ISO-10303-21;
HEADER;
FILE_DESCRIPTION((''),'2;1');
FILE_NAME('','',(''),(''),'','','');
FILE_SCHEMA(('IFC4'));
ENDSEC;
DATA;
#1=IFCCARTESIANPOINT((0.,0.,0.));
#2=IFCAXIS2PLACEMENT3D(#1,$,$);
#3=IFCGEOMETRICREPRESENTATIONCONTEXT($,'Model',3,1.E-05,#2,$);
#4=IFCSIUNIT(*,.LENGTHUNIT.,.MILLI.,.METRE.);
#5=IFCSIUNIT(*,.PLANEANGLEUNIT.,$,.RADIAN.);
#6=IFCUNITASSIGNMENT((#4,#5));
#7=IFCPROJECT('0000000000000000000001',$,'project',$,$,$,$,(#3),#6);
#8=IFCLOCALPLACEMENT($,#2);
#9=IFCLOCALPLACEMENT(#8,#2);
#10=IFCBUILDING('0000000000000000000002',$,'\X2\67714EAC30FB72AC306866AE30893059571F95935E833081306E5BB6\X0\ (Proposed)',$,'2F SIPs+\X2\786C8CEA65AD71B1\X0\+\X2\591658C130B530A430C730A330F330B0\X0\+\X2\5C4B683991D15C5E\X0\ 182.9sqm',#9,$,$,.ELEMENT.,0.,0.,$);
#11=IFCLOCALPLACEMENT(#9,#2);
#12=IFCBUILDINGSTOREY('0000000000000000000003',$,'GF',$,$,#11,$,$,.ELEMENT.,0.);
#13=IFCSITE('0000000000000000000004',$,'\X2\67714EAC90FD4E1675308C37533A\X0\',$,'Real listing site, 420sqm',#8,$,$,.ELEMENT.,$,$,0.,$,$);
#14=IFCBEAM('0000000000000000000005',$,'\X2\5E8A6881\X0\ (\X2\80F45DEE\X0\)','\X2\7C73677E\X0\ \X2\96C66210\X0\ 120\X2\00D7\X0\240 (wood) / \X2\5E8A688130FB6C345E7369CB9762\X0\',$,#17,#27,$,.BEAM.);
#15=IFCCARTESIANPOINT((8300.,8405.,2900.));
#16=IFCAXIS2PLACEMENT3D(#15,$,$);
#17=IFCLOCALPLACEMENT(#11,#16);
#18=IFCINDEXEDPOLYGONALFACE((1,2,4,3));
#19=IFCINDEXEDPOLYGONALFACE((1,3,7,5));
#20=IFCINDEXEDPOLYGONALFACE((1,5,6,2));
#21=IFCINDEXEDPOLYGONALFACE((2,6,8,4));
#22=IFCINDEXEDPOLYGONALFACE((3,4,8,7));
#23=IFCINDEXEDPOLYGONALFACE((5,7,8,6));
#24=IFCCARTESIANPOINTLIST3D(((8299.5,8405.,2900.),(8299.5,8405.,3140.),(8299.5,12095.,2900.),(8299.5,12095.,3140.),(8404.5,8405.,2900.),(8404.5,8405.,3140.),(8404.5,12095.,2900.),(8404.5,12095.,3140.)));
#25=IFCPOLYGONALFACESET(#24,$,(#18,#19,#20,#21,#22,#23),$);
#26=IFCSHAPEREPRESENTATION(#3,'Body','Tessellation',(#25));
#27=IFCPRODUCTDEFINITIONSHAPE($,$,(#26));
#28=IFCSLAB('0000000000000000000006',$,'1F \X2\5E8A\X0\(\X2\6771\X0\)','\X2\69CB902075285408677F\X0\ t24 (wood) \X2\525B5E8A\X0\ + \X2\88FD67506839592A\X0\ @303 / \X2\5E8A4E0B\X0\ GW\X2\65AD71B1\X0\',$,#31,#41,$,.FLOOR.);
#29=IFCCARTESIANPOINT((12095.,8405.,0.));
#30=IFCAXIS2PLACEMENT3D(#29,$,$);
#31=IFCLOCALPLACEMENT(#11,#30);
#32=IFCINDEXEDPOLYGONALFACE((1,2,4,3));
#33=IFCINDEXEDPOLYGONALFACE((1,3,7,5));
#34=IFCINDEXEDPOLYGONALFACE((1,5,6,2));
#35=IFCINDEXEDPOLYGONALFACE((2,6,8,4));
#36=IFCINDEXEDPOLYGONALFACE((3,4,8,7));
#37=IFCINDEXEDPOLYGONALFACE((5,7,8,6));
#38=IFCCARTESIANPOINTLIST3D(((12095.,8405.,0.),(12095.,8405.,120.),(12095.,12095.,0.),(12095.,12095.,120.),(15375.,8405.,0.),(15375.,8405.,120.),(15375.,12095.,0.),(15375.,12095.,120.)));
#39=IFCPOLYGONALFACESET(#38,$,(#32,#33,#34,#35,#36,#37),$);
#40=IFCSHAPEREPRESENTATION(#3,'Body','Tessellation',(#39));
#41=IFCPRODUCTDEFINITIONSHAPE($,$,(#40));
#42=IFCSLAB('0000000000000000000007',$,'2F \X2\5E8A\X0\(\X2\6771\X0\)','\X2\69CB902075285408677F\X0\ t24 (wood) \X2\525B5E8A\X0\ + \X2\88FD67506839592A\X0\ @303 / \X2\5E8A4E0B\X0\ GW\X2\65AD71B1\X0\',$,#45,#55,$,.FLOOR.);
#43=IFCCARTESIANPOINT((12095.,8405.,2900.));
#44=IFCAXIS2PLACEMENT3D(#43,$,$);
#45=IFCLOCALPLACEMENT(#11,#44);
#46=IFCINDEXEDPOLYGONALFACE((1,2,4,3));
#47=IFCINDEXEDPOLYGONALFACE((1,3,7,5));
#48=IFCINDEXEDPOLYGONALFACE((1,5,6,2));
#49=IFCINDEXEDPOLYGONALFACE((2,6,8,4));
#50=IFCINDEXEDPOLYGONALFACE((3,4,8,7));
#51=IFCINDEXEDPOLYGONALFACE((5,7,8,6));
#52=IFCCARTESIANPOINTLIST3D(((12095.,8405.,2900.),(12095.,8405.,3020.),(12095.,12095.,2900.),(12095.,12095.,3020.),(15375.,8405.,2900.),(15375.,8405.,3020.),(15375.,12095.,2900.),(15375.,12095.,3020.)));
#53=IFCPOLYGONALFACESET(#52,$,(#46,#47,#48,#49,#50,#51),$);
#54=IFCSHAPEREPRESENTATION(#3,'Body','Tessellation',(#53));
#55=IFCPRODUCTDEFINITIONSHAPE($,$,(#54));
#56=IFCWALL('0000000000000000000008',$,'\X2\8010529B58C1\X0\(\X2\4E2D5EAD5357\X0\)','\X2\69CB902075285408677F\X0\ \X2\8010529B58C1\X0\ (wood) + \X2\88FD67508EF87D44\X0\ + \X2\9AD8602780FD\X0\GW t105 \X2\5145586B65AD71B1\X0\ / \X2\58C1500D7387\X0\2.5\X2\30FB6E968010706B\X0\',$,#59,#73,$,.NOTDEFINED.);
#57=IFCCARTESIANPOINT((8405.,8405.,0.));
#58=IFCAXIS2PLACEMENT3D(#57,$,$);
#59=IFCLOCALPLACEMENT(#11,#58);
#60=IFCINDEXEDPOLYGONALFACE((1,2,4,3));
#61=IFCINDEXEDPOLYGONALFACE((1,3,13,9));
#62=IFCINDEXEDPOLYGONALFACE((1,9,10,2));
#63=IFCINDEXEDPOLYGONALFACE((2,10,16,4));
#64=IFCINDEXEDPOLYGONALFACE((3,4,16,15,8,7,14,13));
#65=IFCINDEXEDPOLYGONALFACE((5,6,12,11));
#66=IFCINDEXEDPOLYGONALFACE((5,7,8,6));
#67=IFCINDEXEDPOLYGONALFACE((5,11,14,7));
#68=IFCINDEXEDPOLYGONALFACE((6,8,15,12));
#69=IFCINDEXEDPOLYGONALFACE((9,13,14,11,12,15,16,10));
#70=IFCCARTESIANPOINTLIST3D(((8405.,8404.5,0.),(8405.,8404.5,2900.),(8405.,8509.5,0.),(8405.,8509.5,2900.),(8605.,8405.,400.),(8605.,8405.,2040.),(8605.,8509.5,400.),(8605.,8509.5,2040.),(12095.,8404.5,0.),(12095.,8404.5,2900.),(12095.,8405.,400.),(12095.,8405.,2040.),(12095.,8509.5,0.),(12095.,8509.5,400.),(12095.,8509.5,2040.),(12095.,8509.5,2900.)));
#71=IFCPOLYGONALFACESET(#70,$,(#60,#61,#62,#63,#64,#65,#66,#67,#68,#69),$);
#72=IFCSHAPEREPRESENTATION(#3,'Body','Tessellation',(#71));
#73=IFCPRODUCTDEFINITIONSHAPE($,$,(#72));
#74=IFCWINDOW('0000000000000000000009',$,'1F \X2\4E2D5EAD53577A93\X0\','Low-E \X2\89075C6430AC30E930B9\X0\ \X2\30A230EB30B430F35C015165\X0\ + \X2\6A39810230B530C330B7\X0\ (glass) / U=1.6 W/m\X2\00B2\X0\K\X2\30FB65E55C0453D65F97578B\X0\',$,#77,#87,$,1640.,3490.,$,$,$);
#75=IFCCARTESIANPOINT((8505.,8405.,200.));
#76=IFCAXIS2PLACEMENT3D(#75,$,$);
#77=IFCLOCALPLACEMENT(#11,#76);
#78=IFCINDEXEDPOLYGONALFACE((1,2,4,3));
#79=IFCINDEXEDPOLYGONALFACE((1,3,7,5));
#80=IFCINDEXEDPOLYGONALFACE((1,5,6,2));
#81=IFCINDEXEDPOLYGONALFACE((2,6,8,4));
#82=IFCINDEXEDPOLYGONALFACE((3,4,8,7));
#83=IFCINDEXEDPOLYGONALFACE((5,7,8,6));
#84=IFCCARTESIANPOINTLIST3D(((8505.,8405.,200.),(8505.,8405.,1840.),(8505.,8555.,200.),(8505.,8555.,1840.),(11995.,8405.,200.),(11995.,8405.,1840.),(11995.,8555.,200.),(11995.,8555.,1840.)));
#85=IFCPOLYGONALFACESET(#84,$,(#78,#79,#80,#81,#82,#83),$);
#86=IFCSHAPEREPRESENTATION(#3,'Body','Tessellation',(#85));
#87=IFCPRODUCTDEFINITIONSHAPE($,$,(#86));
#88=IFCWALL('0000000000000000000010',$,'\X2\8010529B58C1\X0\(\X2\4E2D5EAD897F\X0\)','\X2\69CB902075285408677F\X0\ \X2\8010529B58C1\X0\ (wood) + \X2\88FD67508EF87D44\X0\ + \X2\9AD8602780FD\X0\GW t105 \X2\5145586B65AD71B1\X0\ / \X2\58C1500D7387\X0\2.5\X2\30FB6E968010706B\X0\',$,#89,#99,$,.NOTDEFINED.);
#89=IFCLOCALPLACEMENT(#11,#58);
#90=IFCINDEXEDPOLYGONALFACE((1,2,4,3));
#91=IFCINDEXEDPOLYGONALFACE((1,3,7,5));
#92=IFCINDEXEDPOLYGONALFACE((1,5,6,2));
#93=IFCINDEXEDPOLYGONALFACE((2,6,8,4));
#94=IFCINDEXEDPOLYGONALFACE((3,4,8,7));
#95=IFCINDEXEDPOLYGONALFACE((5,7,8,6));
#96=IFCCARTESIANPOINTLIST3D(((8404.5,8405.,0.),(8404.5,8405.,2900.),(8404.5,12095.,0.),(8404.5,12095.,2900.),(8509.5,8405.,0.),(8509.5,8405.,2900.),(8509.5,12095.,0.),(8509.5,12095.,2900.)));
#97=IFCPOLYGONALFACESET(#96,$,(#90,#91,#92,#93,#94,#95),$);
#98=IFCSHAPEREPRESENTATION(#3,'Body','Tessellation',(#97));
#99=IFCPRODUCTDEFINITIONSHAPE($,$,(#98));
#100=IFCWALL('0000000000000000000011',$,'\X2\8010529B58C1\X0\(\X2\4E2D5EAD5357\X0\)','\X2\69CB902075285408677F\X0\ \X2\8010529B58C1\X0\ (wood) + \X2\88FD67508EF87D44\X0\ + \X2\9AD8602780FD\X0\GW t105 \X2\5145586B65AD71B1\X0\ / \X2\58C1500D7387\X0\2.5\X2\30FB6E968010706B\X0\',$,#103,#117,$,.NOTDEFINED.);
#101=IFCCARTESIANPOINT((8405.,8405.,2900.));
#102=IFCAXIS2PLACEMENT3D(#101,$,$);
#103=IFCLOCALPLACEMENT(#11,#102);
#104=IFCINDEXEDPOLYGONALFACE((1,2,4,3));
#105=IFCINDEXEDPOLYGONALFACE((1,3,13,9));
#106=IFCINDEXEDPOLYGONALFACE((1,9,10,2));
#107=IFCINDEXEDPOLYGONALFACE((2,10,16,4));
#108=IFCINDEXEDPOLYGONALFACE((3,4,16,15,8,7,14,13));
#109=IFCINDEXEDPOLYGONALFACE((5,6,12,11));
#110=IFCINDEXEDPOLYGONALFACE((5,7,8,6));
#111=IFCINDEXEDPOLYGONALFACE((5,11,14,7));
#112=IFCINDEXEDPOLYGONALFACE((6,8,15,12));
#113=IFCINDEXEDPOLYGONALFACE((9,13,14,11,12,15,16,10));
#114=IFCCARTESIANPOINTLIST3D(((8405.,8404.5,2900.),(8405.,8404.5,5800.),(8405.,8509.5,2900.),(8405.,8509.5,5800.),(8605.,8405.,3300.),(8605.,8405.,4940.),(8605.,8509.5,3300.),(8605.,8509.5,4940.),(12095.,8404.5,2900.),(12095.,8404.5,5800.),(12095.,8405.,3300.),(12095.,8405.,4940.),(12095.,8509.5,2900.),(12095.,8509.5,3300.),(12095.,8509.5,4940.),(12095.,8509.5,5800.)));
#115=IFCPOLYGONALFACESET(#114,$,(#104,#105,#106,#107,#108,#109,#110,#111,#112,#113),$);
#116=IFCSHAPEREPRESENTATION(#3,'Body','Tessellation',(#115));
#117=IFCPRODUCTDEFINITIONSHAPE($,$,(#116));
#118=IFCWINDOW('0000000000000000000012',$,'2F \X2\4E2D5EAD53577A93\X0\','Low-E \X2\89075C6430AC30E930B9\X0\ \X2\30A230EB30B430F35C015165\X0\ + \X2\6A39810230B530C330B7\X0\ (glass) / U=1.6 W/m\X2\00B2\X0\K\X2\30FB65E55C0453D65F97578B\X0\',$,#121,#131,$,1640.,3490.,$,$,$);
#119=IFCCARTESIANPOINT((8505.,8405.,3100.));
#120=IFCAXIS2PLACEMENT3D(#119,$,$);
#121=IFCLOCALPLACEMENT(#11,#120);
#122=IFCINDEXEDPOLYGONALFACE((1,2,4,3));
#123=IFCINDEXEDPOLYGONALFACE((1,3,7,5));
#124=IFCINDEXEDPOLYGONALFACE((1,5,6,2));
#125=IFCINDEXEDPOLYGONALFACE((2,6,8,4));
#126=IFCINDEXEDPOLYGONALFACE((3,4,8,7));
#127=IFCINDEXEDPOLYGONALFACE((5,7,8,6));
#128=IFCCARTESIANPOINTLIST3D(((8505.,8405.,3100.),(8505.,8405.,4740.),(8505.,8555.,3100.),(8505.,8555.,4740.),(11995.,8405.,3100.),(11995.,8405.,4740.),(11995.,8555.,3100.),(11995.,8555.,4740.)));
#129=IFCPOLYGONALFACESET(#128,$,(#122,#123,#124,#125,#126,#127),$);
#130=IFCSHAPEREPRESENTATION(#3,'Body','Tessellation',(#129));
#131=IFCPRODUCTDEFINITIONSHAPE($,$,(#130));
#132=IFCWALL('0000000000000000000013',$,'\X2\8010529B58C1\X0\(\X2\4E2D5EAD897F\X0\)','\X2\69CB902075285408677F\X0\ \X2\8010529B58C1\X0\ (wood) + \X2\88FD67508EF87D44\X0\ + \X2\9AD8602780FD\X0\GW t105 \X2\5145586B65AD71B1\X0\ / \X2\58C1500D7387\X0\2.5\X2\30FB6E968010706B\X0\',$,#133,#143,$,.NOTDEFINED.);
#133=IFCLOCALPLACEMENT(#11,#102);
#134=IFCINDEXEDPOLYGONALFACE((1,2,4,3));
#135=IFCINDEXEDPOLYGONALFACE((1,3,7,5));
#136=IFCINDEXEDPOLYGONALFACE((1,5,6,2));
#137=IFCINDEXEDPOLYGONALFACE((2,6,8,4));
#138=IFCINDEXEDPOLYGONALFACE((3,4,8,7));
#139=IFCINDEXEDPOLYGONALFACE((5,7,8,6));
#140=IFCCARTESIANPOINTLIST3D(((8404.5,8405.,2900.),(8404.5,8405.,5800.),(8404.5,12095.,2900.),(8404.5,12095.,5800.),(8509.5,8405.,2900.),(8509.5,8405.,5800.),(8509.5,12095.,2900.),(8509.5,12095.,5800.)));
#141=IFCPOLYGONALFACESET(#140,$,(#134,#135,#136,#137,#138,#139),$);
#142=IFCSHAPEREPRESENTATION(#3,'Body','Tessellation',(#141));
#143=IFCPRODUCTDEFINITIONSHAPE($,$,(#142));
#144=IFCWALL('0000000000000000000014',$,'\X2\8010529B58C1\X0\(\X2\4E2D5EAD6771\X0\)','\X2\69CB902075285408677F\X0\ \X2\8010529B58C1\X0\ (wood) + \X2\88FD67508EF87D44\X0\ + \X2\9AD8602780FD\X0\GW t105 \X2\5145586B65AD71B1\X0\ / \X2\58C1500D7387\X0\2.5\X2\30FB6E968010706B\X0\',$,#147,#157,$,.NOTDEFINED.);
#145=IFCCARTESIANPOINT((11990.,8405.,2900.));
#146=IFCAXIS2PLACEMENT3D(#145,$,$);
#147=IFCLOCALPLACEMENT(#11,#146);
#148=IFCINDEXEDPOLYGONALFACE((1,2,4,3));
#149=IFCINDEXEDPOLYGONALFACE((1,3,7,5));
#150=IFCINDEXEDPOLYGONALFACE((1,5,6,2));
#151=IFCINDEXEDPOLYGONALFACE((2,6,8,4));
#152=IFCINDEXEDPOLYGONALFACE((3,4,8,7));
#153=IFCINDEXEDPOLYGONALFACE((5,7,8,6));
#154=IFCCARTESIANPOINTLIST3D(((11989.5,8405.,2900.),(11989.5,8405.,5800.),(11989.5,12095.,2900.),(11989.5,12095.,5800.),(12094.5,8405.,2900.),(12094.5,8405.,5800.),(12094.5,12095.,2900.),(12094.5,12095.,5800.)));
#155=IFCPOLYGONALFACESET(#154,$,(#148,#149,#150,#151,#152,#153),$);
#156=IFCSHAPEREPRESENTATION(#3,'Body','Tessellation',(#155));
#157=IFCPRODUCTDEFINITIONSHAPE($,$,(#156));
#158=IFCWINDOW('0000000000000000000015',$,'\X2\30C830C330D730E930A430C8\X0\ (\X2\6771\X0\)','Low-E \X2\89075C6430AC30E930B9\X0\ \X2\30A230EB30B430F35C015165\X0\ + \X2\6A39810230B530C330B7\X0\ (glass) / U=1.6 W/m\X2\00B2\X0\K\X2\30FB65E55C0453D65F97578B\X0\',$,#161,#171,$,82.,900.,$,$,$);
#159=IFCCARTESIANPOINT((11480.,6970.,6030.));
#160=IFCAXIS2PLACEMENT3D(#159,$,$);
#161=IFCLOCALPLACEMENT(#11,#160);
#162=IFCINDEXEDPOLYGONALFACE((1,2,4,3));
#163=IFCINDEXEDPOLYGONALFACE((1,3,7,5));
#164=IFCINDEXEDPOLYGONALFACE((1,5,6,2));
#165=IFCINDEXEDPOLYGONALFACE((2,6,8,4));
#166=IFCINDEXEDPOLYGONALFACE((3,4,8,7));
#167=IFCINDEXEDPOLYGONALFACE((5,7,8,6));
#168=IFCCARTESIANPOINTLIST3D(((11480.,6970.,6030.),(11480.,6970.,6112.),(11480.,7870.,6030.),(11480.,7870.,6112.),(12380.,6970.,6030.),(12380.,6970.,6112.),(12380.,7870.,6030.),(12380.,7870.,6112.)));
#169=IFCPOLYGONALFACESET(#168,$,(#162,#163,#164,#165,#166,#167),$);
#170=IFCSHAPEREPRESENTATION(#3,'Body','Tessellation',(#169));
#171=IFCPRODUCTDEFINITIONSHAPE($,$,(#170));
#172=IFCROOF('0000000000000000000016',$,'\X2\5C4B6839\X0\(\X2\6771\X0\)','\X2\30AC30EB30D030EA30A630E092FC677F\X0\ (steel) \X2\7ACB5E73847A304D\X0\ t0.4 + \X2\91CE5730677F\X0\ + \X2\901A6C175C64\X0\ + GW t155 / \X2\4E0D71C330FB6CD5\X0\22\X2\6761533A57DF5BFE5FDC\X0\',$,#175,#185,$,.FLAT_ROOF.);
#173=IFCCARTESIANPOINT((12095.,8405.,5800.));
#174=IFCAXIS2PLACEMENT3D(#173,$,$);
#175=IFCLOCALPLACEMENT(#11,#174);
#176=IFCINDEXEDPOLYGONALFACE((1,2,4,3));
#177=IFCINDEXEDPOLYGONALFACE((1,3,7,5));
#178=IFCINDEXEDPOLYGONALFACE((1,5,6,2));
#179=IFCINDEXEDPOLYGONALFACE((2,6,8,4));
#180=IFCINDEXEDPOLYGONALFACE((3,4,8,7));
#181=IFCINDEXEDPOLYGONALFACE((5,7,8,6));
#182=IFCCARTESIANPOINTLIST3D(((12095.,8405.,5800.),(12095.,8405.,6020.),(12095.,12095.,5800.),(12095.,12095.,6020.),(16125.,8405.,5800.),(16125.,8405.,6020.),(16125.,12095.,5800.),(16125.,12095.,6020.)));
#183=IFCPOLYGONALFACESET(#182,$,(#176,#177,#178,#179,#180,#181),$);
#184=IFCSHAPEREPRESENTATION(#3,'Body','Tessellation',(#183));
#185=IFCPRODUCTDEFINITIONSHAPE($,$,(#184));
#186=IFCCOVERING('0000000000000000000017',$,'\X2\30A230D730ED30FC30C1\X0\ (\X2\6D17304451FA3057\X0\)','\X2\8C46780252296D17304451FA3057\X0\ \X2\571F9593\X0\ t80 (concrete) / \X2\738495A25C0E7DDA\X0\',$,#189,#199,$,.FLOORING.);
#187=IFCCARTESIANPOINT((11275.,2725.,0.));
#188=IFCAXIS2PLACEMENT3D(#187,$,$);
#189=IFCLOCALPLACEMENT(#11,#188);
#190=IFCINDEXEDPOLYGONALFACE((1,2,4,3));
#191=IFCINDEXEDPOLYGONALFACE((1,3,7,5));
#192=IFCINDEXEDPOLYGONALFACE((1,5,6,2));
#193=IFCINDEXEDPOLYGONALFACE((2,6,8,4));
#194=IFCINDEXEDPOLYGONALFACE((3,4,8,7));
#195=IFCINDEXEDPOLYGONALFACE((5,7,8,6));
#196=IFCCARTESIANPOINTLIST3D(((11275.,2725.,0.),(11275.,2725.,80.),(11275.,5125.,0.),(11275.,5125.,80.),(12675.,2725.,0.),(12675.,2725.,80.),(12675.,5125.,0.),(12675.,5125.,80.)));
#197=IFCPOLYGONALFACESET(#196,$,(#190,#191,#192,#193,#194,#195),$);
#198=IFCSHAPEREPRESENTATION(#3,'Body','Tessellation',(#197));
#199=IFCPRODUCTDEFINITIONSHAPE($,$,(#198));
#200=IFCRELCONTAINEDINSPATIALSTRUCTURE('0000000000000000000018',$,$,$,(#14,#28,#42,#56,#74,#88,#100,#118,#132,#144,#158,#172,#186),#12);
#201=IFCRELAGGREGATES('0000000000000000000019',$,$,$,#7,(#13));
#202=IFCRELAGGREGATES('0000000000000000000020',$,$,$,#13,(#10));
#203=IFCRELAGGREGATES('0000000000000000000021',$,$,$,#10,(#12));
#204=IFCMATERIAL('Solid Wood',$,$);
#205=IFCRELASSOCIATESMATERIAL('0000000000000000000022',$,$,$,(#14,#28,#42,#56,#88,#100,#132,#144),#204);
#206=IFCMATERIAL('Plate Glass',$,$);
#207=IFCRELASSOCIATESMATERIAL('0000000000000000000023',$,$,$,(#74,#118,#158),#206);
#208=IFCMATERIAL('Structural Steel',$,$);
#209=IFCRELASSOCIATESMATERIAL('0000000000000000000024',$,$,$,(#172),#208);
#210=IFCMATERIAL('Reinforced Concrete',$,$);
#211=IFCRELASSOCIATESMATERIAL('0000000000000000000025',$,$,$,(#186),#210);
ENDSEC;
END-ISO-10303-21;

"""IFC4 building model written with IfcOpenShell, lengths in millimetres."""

from ifc_helpers import new_model, si_unit, frame, frame_2d, origin, place, context, project, spatial, rectangle, extrude, material, element, fill, save


model = new_model("IFC4")

# Units and contexts
model_context = context("Model", 3, precision=1e-05, world=origin())
ifc_project = project(units=[si_unit("LENGTHUNIT", "METRE", prefix="MILLI"), si_unit("PLANEANGLEUNIT", "RADIAN")], contexts=[model_context])

# Site, building, storey
site_placement = place(None, origin())
site = spatial("IfcSite", under=ifc_project, at=site_placement, Name="東京都世田谷区", ObjectType="Real listing site, 420sqm", CompositionType="ELEMENT", RefElevation=0.0)
building_placement = place(site_placement, origin())
building = spatial("IfcBuilding", under=site, at=building_placement, Name="東京・犬と暮らす土間広めの家 (Proposed)", ObjectType="2F SIPs+硬質断熱+外壁サイディング+屋根金属 182.9sqm", CompositionType="ELEMENT", ElevationOfRefHeight=0.0, ElevationOfTerrain=0.0)
storey_placement = place(building_placement, origin())
storey = spatial("IfcBuildingStorey", under=building, at=storey_placement, Name="GF", CompositionType="ELEMENT", Elevation=0.0)

# Shared definitions
ifc_material_1 = material(Name="Solid Wood")

# Beam
beam_placement = place(storey_placement, frame((8300.0, 8405.0, 2900.0)))
element("IfcBeam", 1, at=beam_placement, inside=storey, material=ifc_material_1, Name="床梁 (胴差)", Description="米松 集成 120×240 (wood) / 床梁・水平構面", PredefinedType="BEAM", context=model_context, shape_type="SweptSolid", body=[
    extrude(rectangle(XDim=105.0, YDim=3690.0, at=frame_2d((52.0, 1845.0))), frame((8300.0, 8405.0, 2900.0)), (0.0, 0.0, 1.0), 240.0),
])

# Slabs
slab_1_placement = place(storey_placement, frame((12095.0, 8405.0, 0.0)))
element("IfcSlab", 2, at=slab_1_placement, inside=storey, material=ifc_material_1, Name="1F 床(東)", Description="構造用合板 t24 (wood) 剛床 + 製材根太 @303 / 床下 GW断熱", PredefinedType="FLOOR", context=model_context, shape_type="SweptSolid", body=[
    extrude(rectangle(XDim=3280.0, YDim=3690.0, at=frame_2d((1640.0, 1845.0))), frame((12095.0, 8405.0, 0.0)), (0.0, 0.0, 1.0), 120.0),
])
slab_2_placement = place(storey_placement, frame((12095.0, 8405.0, 2900.0)))
element("IfcSlab", 3, at=slab_2_placement, inside=storey, material=ifc_material_1, Name="2F 床(東)", Description="構造用合板 t24 (wood) 剛床 + 製材根太 @303 / 床下 GW断熱", PredefinedType="FLOOR", context=model_context, shape_type="SweptSolid", body=[
    extrude(rectangle(XDim=3280.0, YDim=3690.0, at=frame_2d((1640.0, 1845.0))), frame((12095.0, 8405.0, 2900.0)), (0.0, 0.0, 1.0), 120.0),
])

# Wall, opening, window
wall_1_placement = place(storey_placement, frame((8405.0, 8405.0, 0.0)))
wall_1 = element("IfcWall", 4, at=wall_1_placement, inside=storey, material=ifc_material_1, Name="耐力壁(中庭南)", Description="構造用合板 耐力壁 (wood) + 製材軸組 + 高性能GW t105 充填断熱 / 壁倍率2.5・準耐火", PredefinedType="NOTDEFINED", context=model_context, shape_type="SweptSolid", body=[
    extrude(rectangle(XDim=3690.0, YDim=105.0, at=frame_2d((1845.0, 52.0))), frame((8405.0, 8405.0, 0.0)), (0.0, 0.0, 1.0), 2900.0),
])
opening_1_placement = place(storey_placement, frame((8505.0, 8405.0, 200.0)))
opening_1 = element("IfcOpeningElement", 5, at=opening_1_placement, cuts=wall_1, PredefinedType="NOTDEFINED", context=model_context, shape_type="SweptSolid", body=[
    extrude(rectangle(XDim=3490.0, YDim=150.0, at=frame_2d((1745.0, 75.0))), frame((8505.0, 8405.0, 200.0)), (0.0, 0.0, 1.0), 1640.0),
])
ifc_material_2 = material(Name="Plate Glass")
window_1_placement = place(storey_placement, frame((8505.0, 8405.0, 200.0)))
window_1 = element("IfcWindow", 6, at=window_1_placement, inside=storey, material=ifc_material_2, Name="1F 中庭南窓", Description="Low-E 複層ガラス アルゴン封入 + 樹脂サッシ (glass) / U=1.6 W/m²K・日射取得型", OverallHeight=1640.0, OverallWidth=3490.0, context=model_context, shape_type="SweptSolid", body=[
    extrude(rectangle(XDim=3490.0, YDim=150.0, at=frame_2d((1745.0, 75.0))), frame((8505.0, 8405.0, 200.0)), (0.0, 0.0, 1.0), 1640.0),
])
fill(opening_1, window_1)

# Wall
wall_2_placement = place(storey_placement, frame((8405.0, 8405.0, 0.0)))
element("IfcWall", 7, at=wall_2_placement, inside=storey, material=ifc_material_1, Name="耐力壁(中庭西)", Description="構造用合板 耐力壁 (wood) + 製材軸組 + 高性能GW t105 充填断熱 / 壁倍率2.5・準耐火", PredefinedType="NOTDEFINED", context=model_context, shape_type="SweptSolid", body=[
    extrude(rectangle(XDim=105.0, YDim=3690.0, at=frame_2d((52.0, 1845.0))), frame((8405.0, 8405.0, 0.0)), (0.0, 0.0, 1.0), 2900.0),
])

# Wall, opening, window
wall_3_placement = place(storey_placement, frame((8405.0, 8405.0, 2900.0)))
wall_3 = element("IfcWall", 8, at=wall_3_placement, inside=storey, material=ifc_material_1, Name="耐力壁(中庭南)", Description="構造用合板 耐力壁 (wood) + 製材軸組 + 高性能GW t105 充填断熱 / 壁倍率2.5・準耐火", PredefinedType="NOTDEFINED", context=model_context, shape_type="SweptSolid", body=[
    extrude(rectangle(XDim=3690.0, YDim=105.0, at=frame_2d((1845.0, 52.0))), frame((8405.0, 8405.0, 2900.0)), (0.0, 0.0, 1.0), 2900.0),
])
opening_2_placement = place(storey_placement, frame((8505.0, 8405.0, 3100.0)))
opening_2 = element("IfcOpeningElement", 9, at=opening_2_placement, cuts=wall_3, PredefinedType="NOTDEFINED", context=model_context, shape_type="SweptSolid", body=[
    extrude(rectangle(XDim=3490.0, YDim=150.0, at=frame_2d((1745.0, 75.0))), frame((8505.0, 8405.0, 3100.0)), (0.0, 0.0, 1.0), 1640.0),
])
window_2_placement = place(storey_placement, frame((8505.0, 8405.0, 3100.0)))
window_2 = element("IfcWindow", 10, at=window_2_placement, inside=storey, material=ifc_material_2, Name="2F 中庭南窓", Description="Low-E 複層ガラス アルゴン封入 + 樹脂サッシ (glass) / U=1.6 W/m²K・日射取得型", OverallHeight=1640.0, OverallWidth=3490.0, context=model_context, shape_type="SweptSolid", body=[
    extrude(rectangle(XDim=3490.0, YDim=150.0, at=frame_2d((1745.0, 75.0))), frame((8505.0, 8405.0, 3100.0)), (0.0, 0.0, 1.0), 1640.0),
])
fill(opening_2, window_2)

# Walls
wall_4_placement = place(storey_placement, frame((8405.0, 8405.0, 2900.0)))
element("IfcWall", 11, at=wall_4_placement, inside=storey, material=ifc_material_1, Name="耐力壁(中庭西)", Description="構造用合板 耐力壁 (wood) + 製材軸組 + 高性能GW t105 充填断熱 / 壁倍率2.5・準耐火", PredefinedType="NOTDEFINED", context=model_context, shape_type="SweptSolid", body=[
    extrude(rectangle(XDim=105.0, YDim=3690.0, at=frame_2d((52.0, 1845.0))), frame((8405.0, 8405.0, 2900.0)), (0.0, 0.0, 1.0), 2900.0),
])
wall_5_placement = place(storey_placement, frame((11990.0, 8405.0, 2900.0)))
element("IfcWall", 12, at=wall_5_placement, inside=storey, material=ifc_material_1, Name="耐力壁(中庭東)", Description="構造用合板 耐力壁 (wood) + 製材軸組 + 高性能GW t105 充填断熱 / 壁倍率2.5・準耐火", PredefinedType="NOTDEFINED", context=model_context, shape_type="SweptSolid", body=[
    extrude(rectangle(XDim=105.0, YDim=3690.0, at=frame_2d((52.0, 1845.0))), frame((11990.0, 8405.0, 2900.0)), (0.0, 0.0, 1.0), 2900.0),
])

# Window
window_3_placement = place(storey_placement, frame((11480.0, 6970.0, 6030.0)))
element("IfcWindow", 13, at=window_3_placement, inside=storey, material=ifc_material_2, Name="トップライト (東)", Description="Low-E 複層ガラス アルゴン封入 + 樹脂サッシ (glass) / U=1.6 W/m²K・日射取得型", OverallHeight=82.0, OverallWidth=900.0, context=model_context, shape_type="SweptSolid", body=[
    extrude(rectangle(XDim=900.0, YDim=900.0, at=frame_2d((450.0, 450.0))), frame((11480.0, 6970.0, 6030.0)), (0.0, 0.0, 1.0), 82.0),
])

# Roof
ifc_material_3 = material(Name="Structural Steel")
roof_placement = place(storey_placement, frame((12095.0, 8405.0, 5800.0)))
element("IfcRoof", 14, at=roof_placement, inside=storey, material=ifc_material_3, Name="屋根(東)", Description="ガルバリウム鋼板 (steel) 立平葺き t0.4 + 野地板 + 通気層 + GW t155 / 不燃・法22条区域対応", PredefinedType="FLAT_ROOF", context=model_context, shape_type="SweptSolid", body=[
    extrude(rectangle(XDim=4030.0, YDim=3690.0, at=frame_2d((2015.0, 1845.0))), frame((12095.0, 8405.0, 5800.0)), (0.0, 0.0, 1.0), 220.0),
])

# Covering
ifc_material_4 = material(Name="Reinforced Concrete")
covering_1_placement = place(storey_placement, frame((11275.0, 2725.0, 0.0)))
element("IfcCovering", 15, at=covering_1_placement, inside=storey, material=ifc_material_4, Name="アプローチ (洗い出し)", Description="豆砂利洗い出し 土間 t80 (concrete) / 玄関導線", PredefinedType="FLOORING", context=model_context, shape_type="SweptSolid", body=[
    extrude(rectangle(XDim=1400.0, YDim=2400.0, at=frame_2d((700.0, 1200.0))), frame((11275.0, 2725.0, 0.0)), (0.0, 0.0, 1.0), 80.0),
])

save(model, "model.ifc")
